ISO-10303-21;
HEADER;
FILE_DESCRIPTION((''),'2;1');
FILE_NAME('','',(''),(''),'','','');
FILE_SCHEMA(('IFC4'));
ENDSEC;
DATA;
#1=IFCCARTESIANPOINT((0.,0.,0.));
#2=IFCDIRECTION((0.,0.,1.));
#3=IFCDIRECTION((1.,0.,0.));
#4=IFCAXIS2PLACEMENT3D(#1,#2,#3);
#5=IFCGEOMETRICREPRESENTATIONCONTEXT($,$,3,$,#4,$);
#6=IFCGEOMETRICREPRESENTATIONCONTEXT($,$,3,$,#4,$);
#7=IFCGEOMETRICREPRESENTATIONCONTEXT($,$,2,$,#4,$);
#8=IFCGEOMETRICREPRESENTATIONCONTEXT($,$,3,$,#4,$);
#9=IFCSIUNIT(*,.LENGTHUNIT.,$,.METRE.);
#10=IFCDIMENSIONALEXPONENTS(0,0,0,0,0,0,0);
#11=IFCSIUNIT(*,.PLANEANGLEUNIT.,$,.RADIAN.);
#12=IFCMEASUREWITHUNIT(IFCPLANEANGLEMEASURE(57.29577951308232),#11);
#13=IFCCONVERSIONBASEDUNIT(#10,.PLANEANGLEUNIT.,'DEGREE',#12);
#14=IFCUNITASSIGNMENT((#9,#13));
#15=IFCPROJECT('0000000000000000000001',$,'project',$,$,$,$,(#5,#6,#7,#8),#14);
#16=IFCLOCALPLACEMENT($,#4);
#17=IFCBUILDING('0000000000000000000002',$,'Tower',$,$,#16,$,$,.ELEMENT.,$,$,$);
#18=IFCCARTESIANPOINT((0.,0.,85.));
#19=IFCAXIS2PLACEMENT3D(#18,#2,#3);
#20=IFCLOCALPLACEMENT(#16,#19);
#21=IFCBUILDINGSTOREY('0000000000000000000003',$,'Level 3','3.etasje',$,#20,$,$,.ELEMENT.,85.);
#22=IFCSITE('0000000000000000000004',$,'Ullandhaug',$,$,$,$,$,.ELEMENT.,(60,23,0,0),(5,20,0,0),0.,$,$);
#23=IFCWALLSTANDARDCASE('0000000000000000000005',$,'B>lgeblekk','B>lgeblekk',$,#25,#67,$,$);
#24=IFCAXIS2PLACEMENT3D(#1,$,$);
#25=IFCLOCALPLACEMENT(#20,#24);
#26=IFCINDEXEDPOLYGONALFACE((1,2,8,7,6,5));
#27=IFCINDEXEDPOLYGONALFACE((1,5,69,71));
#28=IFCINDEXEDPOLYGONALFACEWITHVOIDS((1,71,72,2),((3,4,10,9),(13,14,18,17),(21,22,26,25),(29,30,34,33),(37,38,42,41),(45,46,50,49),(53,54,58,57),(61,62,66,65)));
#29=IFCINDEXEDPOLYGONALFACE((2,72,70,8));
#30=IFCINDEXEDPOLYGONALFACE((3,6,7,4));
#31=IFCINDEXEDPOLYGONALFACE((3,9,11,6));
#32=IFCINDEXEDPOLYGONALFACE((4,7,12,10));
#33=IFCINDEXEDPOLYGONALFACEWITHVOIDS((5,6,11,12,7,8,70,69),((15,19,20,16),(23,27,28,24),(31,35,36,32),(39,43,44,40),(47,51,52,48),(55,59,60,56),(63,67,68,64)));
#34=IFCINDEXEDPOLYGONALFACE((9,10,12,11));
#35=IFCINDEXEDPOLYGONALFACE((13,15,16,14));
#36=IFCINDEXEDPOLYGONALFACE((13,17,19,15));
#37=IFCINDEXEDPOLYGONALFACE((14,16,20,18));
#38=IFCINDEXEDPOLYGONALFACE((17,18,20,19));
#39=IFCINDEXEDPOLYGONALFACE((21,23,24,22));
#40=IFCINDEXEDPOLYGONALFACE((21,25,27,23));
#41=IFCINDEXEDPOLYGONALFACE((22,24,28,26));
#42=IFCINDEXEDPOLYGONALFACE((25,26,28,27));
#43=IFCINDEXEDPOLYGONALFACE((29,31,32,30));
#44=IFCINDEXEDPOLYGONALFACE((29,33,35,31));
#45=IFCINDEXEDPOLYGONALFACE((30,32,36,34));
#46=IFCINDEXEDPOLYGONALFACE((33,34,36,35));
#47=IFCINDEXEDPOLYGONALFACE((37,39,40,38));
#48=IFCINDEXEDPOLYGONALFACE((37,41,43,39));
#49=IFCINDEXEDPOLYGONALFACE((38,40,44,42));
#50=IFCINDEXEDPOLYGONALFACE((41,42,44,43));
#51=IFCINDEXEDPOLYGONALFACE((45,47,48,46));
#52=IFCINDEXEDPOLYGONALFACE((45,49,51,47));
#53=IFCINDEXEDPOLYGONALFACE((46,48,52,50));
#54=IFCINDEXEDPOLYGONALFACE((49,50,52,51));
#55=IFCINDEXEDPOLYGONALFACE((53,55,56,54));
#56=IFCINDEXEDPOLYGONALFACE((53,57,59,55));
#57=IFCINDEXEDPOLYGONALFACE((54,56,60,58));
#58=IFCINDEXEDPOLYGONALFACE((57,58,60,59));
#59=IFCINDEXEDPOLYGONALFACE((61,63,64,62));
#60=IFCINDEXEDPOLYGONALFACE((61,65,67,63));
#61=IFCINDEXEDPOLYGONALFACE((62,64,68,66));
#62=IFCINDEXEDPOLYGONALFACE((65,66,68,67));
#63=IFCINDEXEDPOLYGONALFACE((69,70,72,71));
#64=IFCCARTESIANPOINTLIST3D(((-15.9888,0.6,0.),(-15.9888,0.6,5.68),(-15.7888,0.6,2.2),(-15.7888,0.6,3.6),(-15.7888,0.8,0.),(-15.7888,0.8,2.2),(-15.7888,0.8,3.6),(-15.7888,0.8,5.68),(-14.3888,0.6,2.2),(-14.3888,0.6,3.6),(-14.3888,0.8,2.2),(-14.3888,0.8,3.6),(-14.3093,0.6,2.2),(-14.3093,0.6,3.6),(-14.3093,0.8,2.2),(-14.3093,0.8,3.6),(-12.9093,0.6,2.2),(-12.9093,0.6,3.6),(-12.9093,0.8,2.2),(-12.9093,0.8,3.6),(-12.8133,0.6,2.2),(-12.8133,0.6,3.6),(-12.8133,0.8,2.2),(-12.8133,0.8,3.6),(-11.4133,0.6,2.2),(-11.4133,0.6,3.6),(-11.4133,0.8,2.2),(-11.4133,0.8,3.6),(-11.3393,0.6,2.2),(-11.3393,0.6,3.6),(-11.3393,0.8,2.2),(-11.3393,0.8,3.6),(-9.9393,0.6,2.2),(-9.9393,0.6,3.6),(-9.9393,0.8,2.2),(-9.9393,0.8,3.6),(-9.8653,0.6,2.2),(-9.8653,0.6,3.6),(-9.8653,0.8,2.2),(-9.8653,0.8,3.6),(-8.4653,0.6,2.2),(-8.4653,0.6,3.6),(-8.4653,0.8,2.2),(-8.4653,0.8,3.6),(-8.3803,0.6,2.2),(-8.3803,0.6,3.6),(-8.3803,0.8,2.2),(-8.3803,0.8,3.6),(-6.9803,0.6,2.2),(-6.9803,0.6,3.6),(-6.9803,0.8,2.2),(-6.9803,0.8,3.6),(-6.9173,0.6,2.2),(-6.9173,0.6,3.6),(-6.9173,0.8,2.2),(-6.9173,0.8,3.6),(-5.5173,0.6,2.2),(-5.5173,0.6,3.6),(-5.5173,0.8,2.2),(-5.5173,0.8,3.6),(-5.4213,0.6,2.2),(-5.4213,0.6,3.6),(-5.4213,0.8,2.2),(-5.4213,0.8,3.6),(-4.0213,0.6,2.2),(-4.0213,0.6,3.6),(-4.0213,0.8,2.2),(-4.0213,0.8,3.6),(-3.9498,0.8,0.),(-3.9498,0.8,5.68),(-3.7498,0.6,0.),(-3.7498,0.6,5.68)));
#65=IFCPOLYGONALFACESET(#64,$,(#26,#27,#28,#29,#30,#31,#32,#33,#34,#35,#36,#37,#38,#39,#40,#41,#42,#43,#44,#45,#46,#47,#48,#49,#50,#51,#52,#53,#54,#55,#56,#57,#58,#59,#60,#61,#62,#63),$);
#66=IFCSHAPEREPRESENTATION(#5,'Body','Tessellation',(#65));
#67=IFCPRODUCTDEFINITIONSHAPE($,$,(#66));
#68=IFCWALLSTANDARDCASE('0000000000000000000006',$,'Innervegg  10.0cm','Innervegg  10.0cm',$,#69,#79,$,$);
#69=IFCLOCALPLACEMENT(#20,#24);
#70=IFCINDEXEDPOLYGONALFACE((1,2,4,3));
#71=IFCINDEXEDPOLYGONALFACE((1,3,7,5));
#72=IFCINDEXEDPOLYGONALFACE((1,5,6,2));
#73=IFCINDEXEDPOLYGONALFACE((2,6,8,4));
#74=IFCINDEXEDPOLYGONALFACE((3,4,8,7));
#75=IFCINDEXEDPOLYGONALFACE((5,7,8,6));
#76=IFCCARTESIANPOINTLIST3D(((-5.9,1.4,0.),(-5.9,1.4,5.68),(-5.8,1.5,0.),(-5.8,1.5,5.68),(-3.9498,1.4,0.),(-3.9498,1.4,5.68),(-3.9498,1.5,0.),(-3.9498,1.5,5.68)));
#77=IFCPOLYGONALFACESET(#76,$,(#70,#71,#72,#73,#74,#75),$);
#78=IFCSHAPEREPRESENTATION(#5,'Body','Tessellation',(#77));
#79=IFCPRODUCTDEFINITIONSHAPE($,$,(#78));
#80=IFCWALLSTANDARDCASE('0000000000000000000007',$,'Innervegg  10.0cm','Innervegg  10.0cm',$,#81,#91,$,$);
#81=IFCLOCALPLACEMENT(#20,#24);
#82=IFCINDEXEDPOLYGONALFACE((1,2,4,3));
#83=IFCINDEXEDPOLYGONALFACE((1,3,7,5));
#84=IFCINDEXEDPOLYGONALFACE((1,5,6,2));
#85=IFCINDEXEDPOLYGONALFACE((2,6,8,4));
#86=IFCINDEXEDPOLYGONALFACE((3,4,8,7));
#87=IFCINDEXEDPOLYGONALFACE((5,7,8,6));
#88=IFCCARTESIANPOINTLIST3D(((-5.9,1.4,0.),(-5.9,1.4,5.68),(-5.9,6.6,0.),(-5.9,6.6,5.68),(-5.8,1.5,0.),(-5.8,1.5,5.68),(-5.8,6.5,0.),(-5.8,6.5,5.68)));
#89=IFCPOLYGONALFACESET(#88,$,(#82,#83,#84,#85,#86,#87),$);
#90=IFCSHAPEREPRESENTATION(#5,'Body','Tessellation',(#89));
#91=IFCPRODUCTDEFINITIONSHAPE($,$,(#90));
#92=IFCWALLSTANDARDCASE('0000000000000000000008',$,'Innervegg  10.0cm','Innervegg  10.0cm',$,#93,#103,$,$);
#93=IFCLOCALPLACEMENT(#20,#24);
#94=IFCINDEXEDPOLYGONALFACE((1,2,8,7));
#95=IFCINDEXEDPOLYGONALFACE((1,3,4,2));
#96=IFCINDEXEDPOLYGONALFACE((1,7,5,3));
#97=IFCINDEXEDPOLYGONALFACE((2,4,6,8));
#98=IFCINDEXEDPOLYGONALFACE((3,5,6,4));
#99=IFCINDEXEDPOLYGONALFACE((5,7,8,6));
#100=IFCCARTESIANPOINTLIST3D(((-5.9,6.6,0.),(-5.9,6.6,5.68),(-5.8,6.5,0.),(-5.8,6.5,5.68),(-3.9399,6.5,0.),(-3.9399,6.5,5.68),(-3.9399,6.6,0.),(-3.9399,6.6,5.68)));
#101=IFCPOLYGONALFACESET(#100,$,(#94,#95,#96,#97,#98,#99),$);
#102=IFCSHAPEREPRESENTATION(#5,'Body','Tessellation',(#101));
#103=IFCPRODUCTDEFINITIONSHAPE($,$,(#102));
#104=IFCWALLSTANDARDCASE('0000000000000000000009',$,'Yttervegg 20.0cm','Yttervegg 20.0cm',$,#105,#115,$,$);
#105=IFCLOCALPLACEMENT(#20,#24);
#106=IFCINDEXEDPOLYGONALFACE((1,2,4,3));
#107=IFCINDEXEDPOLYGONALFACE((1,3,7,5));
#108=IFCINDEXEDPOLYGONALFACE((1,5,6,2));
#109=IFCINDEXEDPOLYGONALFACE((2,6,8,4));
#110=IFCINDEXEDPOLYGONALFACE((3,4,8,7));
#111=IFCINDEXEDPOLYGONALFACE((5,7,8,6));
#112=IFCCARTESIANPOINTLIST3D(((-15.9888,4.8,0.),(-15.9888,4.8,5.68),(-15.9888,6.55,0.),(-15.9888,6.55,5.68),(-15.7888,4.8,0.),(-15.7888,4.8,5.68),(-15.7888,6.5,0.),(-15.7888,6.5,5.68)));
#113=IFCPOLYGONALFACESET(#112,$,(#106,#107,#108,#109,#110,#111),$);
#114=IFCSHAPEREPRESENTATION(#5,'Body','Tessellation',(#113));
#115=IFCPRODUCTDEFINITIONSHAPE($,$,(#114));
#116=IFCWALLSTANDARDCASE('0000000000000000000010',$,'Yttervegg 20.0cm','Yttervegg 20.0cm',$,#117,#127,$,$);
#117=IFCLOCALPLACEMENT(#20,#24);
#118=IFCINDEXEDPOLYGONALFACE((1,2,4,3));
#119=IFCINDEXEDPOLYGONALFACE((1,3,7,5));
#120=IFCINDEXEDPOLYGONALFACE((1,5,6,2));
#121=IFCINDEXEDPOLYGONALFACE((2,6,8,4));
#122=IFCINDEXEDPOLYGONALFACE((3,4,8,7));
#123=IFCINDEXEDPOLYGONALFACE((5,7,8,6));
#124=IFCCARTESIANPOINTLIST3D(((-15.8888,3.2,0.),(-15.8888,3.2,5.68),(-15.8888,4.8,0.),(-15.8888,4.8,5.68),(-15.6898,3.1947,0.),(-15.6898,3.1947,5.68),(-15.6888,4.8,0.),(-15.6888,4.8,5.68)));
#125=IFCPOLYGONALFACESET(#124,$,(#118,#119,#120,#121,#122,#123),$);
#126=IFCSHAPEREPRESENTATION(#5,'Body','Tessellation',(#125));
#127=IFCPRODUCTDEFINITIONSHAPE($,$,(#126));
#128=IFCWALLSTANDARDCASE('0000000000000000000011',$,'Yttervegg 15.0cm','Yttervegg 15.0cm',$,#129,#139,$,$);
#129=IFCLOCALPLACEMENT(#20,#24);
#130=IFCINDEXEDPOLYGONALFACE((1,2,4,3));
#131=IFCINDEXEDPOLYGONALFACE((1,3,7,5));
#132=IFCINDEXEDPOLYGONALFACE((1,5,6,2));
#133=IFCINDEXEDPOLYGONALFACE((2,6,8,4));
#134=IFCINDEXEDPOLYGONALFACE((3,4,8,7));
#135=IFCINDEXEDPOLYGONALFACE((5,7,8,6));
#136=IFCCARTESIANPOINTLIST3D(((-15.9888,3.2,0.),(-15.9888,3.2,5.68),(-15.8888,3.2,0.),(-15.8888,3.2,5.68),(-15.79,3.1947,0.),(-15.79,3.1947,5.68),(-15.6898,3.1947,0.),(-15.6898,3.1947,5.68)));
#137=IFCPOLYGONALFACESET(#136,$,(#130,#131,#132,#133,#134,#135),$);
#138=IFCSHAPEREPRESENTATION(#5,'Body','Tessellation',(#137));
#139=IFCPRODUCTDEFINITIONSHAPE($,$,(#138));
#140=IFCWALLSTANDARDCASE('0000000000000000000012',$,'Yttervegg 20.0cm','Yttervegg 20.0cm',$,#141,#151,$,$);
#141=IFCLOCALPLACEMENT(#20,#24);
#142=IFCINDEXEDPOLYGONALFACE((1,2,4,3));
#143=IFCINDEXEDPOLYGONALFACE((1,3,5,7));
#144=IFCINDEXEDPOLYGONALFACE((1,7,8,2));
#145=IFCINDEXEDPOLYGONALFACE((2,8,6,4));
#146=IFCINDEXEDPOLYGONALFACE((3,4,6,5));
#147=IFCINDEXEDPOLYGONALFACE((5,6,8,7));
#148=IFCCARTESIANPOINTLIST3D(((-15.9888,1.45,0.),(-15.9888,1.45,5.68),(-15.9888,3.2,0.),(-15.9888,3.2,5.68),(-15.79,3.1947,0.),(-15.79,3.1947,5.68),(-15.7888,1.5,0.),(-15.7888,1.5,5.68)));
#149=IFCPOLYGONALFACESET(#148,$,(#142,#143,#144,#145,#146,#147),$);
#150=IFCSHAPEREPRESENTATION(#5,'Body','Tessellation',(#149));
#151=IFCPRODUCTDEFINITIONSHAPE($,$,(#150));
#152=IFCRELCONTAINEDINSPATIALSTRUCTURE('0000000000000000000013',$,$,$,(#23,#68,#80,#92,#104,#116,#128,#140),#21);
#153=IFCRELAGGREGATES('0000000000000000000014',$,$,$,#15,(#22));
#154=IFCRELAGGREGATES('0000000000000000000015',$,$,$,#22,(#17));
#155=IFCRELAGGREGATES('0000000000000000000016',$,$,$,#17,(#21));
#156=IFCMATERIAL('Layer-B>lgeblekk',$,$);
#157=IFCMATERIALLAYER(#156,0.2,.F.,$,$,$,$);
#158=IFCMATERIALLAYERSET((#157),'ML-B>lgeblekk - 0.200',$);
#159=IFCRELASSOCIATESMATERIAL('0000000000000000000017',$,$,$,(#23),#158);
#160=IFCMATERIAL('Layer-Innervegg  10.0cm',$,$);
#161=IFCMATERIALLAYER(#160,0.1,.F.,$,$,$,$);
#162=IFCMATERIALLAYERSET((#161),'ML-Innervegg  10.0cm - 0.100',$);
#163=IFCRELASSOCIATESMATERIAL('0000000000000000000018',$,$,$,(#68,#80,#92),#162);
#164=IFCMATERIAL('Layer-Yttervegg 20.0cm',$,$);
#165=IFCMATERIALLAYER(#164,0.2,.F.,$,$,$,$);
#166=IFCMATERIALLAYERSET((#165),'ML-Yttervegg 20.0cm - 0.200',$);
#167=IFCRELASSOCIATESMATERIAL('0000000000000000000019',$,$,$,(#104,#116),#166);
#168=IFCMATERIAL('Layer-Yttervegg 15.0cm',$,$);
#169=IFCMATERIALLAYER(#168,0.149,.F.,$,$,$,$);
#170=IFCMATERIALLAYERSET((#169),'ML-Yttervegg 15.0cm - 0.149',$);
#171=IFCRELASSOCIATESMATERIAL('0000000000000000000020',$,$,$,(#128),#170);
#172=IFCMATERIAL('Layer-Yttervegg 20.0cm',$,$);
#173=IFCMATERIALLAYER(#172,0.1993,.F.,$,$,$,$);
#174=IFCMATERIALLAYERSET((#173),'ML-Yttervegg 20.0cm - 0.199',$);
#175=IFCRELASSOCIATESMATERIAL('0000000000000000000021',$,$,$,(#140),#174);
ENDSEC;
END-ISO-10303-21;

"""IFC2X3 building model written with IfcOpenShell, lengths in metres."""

from ifc_helpers import new_model, entity, si_unit, converted_unit, frame, origin_with_axes, place, context, project, spatial, polyline, outline, extrude, material, layer, layer_set, layer_usage, element, save


model = new_model("IFC2X3")

# Units and contexts
context_of_model_1 = context(None, 3, world=origin_with_axes())
context_of_model_2 = context(None, 3, world=origin_with_axes())
context_of_model_3 = context(None, 2, world=origin_with_axes())
context_of_model_4 = context(None, 3, world=origin_with_axes())
ifc_project = project(units=[si_unit("LENGTHUNIT", "METRE"), converted_unit("PLANEANGLEUNIT", "DEGREE", entity("IfcPlaneAngleMeasure", 57.29577951308232), si_unit("PLANEANGLEUNIT", "RADIAN"), dimensions=[0, 0, 0, 0, 0, 0, 0])], contexts=[context_of_model_1, context_of_model_2, context_of_model_3, context_of_model_4])

# Site, building, storey
site = spatial("IfcSite", under=ifc_project, Name="Ullandhaug", CompositionType="ELEMENT", RefLatitude=(60, 23, 0, 0), RefLongitude=(5, 20, 0, 0), RefElevation=0.0)
building_placement = place(None, origin_with_axes())
building = spatial("IfcBuilding", under=site, at=building_placement, Name="Tower", CompositionType="ELEMENT")
storey_placement = place(building_placement, frame((0.0, 0.0, 85.0), z_axis=(0.0, 0.0, 1.0), x_axis=(1.0, 0.0, 0.0)))
storey = spatial("IfcBuildingStorey", under=building, at=storey_placement, Name="Level 3", Description="3.etasje", CompositionType="ELEMENT", Elevation=85.0)

# Shared definitions
ifc_material_1 = material(Name="Layer-Innervegg  10.0cm")
ifc_layer_1 = layer(ifc_material_1, 0.1, ventilated=False)
ifc_layer_set_1 = layer_set([ifc_layer_1], Name="ML-Innervegg  10.0cm - 0.100")
ifc_layer_usage_1 = layer_usage(ifc_layer_set_1, "AXIS2", "POSITIVE", 0.0)

# Wall, openings
ifc_material_2 = material(Name="Layer-B>lgeblekk")
ifc_layer_2 = layer(ifc_material_2, 0.2, ventilated=False)
ifc_layer_set_2 = layer_set([ifc_layer_2], Name="ML-B>lgeblekk - 0.200")
ifc_layer_usage_2 = layer_usage(ifc_layer_set_2, "AXIS2", "POSITIVE", 0.0)
wall_1_placement = place(storey_placement, frame((-15.9888, 0.6, 0.0), z_axis=(0.0, 0.0, 1.0), x_axis=(1.0, 0.0, 0.0)))
wall_1 = element("IfcWallStandardCase", 1, at=wall_1_placement, inside=storey, material=ifc_layer_usage_2, Name="B>lgeblekk", Description="B>lgeblekk", context=context_of_model_1, shape_type="SweptSolid", body=[
    extrude(outline(polyline([(0.0, 0.0), (12.2391, 0.0), (12.0391, 0.2), (0.2, 0.2), (0.0, 0.0)])), origin_with_axes(), (0.0, 0.0, 1.0), 5.68),
])
opening_1_placement = place(wall_1_placement, frame((0.2, 0.2, 2.2), z_axis=(0.0, 0.0, 1.0), x_axis=(1.0, 0.0, 0.0)))
element("IfcOpeningElement", 2, at=opening_1_placement, cuts=wall_1, context=context_of_model_1, shape_type="SweptSolid", body=[
    extrude(outline(polyline([(0.0, 0.0), (1.4, 0.0), (1.4, 1.4), (0.0, 1.4), (0.0, 0.0)])), frame((0.0, 0.0, 0.0), z_axis=(0.0, 1.0, 0.0), x_axis=(0.0, 0.0, 1.0)), (0.0, 0.0, -1.0), 0.2),
])
opening_2_placement = place(wall_1_placement, frame((1.6796, 0.2, 2.2), z_axis=(0.0, 0.0, 1.0), x_axis=(1.0, 0.0, 0.0)))
element("IfcOpeningElement", 3, at=opening_2_placement, cuts=wall_1, context=context_of_model_1, shape_type="SweptSolid", body=[
    extrude(outline(polyline([(0.0, 0.0), (1.4, 0.0), (1.4, 1.4), (0.0, 1.4), (0.0, 0.0)])), frame((0.0, 0.0, 0.0), z_axis=(0.0, 1.0, 0.0), x_axis=(0.0, 0.0, 1.0)), (0.0, 0.0, -1.0), 0.2),
])
opening_3_placement = place(wall_1_placement, frame((3.1756, 0.2, 2.2), z_axis=(0.0, 0.0, 1.0), x_axis=(1.0, 0.0, 0.0)))
element("IfcOpeningElement", 4, at=opening_3_placement, cuts=wall_1, context=context_of_model_1, shape_type="SweptSolid", body=[
    extrude(outline(polyline([(0.0, 0.0), (1.4, 0.0), (1.4, 1.4), (0.0, 1.4), (0.0, 0.0)])), frame((0.0, 0.0, 0.0), z_axis=(0.0, 1.0, 0.0), x_axis=(0.0, 0.0, 1.0)), (0.0, 0.0, -1.0), 0.2),
])
opening_4_placement = place(wall_1_placement, frame((4.6496, 0.2, 2.2), z_axis=(0.0, 0.0, 1.0), x_axis=(1.0, 0.0, 0.0)))
element("IfcOpeningElement", 5, at=opening_4_placement, cuts=wall_1, context=context_of_model_1, shape_type="SweptSolid", body=[
    extrude(outline(polyline([(0.0, 0.0), (1.4, 0.0), (1.4, 1.4), (0.0, 1.4), (0.0, 0.0)])), frame((0.0, 0.0, 0.0), z_axis=(0.0, 1.0, 0.0), x_axis=(0.0, 0.0, 1.0)), (0.0, 0.0, -1.0), 0.2),
])
opening_5_placement = place(wall_1_placement, frame((6.1236, 0.2, 2.2), z_axis=(0.0, 0.0, 1.0), x_axis=(1.0, 0.0, 0.0)))
element("IfcOpeningElement", 6, at=opening_5_placement, cuts=wall_1, context=context_of_model_1, shape_type="SweptSolid", body=[
    extrude(outline(polyline([(0.0, 0.0), (1.4, 0.0), (1.4, 1.4), (0.0, 1.4), (0.0, 0.0)])), frame((0.0, 0.0, 0.0), z_axis=(0.0, 1.0, 0.0), x_axis=(0.0, 0.0, 1.0)), (0.0, 0.0, -1.0), 0.2),
])
opening_6_placement = place(wall_1_placement, frame((7.6086, 0.2, 2.2), z_axis=(0.0, 0.0, 1.0), x_axis=(1.0, 0.0, 0.0)))
element("IfcOpeningElement", 7, at=opening_6_placement, cuts=wall_1, context=context_of_model_1, shape_type="SweptSolid", body=[
    extrude(outline(polyline([(0.0, 0.0), (1.4, 0.0), (1.4, 1.4), (0.0, 1.4), (0.0, 0.0)])), frame((0.0, 0.0, 0.0), z_axis=(0.0, 1.0, 0.0), x_axis=(0.0, 0.0, 1.0)), (0.0, 0.0, -1.0), 0.2),
])
opening_7_placement = place(wall_1_placement, frame((9.0716, 0.2, 2.2), z_axis=(0.0, 0.0, 1.0), x_axis=(1.0, 0.0, 0.0)))
element("IfcOpeningElement", 8, at=opening_7_placement, cuts=wall_1, context=context_of_model_1, shape_type="SweptSolid", body=[
    extrude(outline(polyline([(0.0, 0.0), (1.4, 0.0), (1.4, 1.4), (0.0, 1.4), (0.0, 0.0)])), frame((0.0, 0.0, 0.0), z_axis=(0.0, 1.0, 0.0), x_axis=(0.0, 0.0, 1.0)), (0.0, 0.0, -1.0), 0.2),
])
opening_8_placement = place(wall_1_placement, frame((10.5676, 0.2, 2.2), z_axis=(0.0, 0.0, 1.0), x_axis=(1.0, 0.0, 0.0)))
element("IfcOpeningElement", 9, at=opening_8_placement, cuts=wall_1, context=context_of_model_1, shape_type="SweptSolid", body=[
    extrude(outline(polyline([(0.0, 0.0), (1.4, 0.0), (1.4, 1.4), (0.0, 1.4), (0.0, 0.0)])), frame((0.0, 0.0, 0.0), z_axis=(0.0, 1.0, 0.0), x_axis=(0.0, 0.0, 1.0)), (0.0, 0.0, -1.0), 0.2),
])

# Walls
wall_2_placement = place(storey_placement, frame((-3.9498, 1.5, 0.0), z_axis=(0.0, 0.0, 1.0), x_axis=(-1.0, 0.0, 0.0)))
element("IfcWallStandardCase", 10, at=wall_2_placement, inside=storey, material=ifc_layer_usage_1, Name="Innervegg  10.0cm", Description="Innervegg  10.0cm", context=context_of_model_1, shape_type="SweptSolid", body=[
    extrude(outline(polyline([(0.0, 0.0), (1.8502, 0.0), (1.9502, 0.1), (0.0, 0.1), (0.0, 0.0)])), frame((0.0, 0.0, 0.0), z_axis=(0.0, 0.0, 1.0), x_axis=(1.0, 0.0, 0.0)), (0.0, 0.0, 1.0), 5.68),
])
wall_3_placement = place(storey_placement, frame((-5.8, 1.5, 0.0), z_axis=(0.0, 0.0, 1.0), x_axis=(0.0, 1.0, 0.0)))
element("IfcWallStandardCase", 11, at=wall_3_placement, inside=storey, material=ifc_layer_usage_1, Name="Innervegg  10.0cm", Description="Innervegg  10.0cm", context=context_of_model_1, shape_type="SweptSolid", body=[
    extrude(outline(polyline([(0.0, 0.0), (5.0, 0.0), (5.1, 0.1), (-0.1, 0.1), (0.0, 0.0)])), frame((0.0, 0.0, 0.0), z_axis=(0.0, 0.0, 1.0), x_axis=(1.0, 0.0, 0.0)), (0.0, 0.0, 1.0), 5.68),
])
wall_4_placement = place(storey_placement, frame((-5.8, 6.5, 0.0), z_axis=(0.0, 0.0, 1.0), x_axis=(1.0, 0.0, 0.0)))
element("IfcWallStandardCase", 12, at=wall_4_placement, inside=storey, material=ifc_layer_usage_1, Name="Innervegg  10.0cm", Description="Innervegg  10.0cm", context=context_of_model_1, shape_type="SweptSolid", body=[
    extrude(outline(polyline([(0.0, 0.0), (1.8601, 0.0), (1.8601, 0.1), (-0.1, 0.1), (0.0, 0.0)])), origin_with_axes(), (0.0, 0.0, 1.0), 5.68),
])
ifc_material_3 = material(Name="Layer-Yttervegg 20.0cm")
ifc_layer_3 = layer(ifc_material_3, 0.2, ventilated=False)
ifc_layer_set_3 = layer_set([ifc_layer_3], Name="ML-Yttervegg 20.0cm - 0.200")
ifc_layer_usage_3 = layer_usage(ifc_layer_set_3, "AXIS2", "POSITIVE", 0.0)
wall_5_placement = place(storey_placement, frame((-15.9888, 6.55, 0.0), z_axis=(0.0, 0.0, 1.0), x_axis=(0.0, -1.0, 0.0)))
element("IfcWallStandardCase", 13, at=wall_5_placement, inside=storey, material=ifc_layer_usage_3, Name="Yttervegg 20.0cm", Description="Yttervegg 20.0cm", context=context_of_model_1, shape_type="SweptSolid", body=[
    extrude(outline(polyline([(0.0, 0.0), (1.75, 0.0), (1.75, 0.2), (0.05, 0.2), (0.0, 0.0)])), frame((0.0, 0.0, 0.0), z_axis=(0.0, 0.0, 1.0), x_axis=(1.0, 0.0, 0.0)), (0.0, 0.0, 1.0), 5.68),
])
wall_6_placement = place(storey_placement, frame((-15.8888, 4.8, 0.0), z_axis=(0.0, 0.0, 1.0), x_axis=(0.000001, -1.0, 0.0)))
element("IfcWallStandardCase", 14, at=wall_6_placement, inside=storey, material=ifc_layer_usage_3, Name="Yttervegg 20.0cm", Description="Yttervegg 20.0cm", context=context_of_model_1, shape_type="SweptSolid", body=[
    extrude(outline(polyline([(0.0, 0.0), (1.6, 0.0), (1.6053, 0.199), (0.0, 0.2), (0.0, 0.0)])), frame((0.0, 0.0, 0.0), z_axis=(0.0, 0.0, 1.0), x_axis=(1.0, 0.0, 0.0)), (0.0, 0.0, 1.0), 5.68),
])
ifc_material_4 = material(Name="Layer-Yttervegg 15.0cm")
ifc_layer_4 = layer(ifc_material_4, 0.149, ventilated=False)
ifc_layer_set_4 = layer_set([ifc_layer_4], Name="ML-Yttervegg 15.0cm - 0.149")
ifc_layer_usage_4 = layer_usage(ifc_layer_set_4, "AXIS2", "POSITIVE", 0.0)
wall_7_placement = place(storey_placement, frame((-15.8888, 3.2, 0.0), z_axis=(0.0, 0.0, 1.0), x_axis=(-1.0, 0.0, 0.0)))
element("IfcWallStandardCase", 15, at=wall_7_placement, inside=storey, material=ifc_layer_usage_4, Name="Yttervegg 15.0cm", Description="Yttervegg 15.0cm", context=context_of_model_1, shape_type="SweptSolid", body=[
    extrude(outline(polyline([(0.0, 0.0), (0.1, 0.0), (-0.0989, 0.0053), (-0.199, 0.0053), (0.0, 0.0)])), frame((0.0, 0.0, 0.0), z_axis=(0.0, 0.0, 1.0), x_axis=(1.0, 0.0, 0.0)), (0.0, 0.0, 1.0), 5.68),
])
ifc_material_5 = material(Name="Layer-Yttervegg 20.0cm")
ifc_layer_5 = layer(ifc_material_5, 0.1993, ventilated=False)
ifc_layer_set_5 = layer_set([ifc_layer_5], Name="ML-Yttervegg 20.0cm - 0.199")
ifc_layer_usage_5 = layer_usage(ifc_layer_set_5, "AXIS2", "POSITIVE", 0.0)
wall_8_placement = place(storey_placement, frame((-15.9888, 3.2, 0.0), z_axis=(0.0, 0.0, 1.0), x_axis=(0.0, -1.0, 0.0)))
element("IfcWallStandardCase", 16, at=wall_8_placement, inside=storey, material=ifc_layer_usage_5, Name="Yttervegg 20.0cm", Description="Yttervegg 20.0cm", context=context_of_model_1, shape_type="SweptSolid", body=[
    extrude(outline(polyline([(0.0, 0.0), (1.75, 0.0), (1.7, 0.2), (0.0053, 0.1989), (0.0, 0.0)])), frame((0.0, 0.0, 0.0), z_axis=(0.0, 0.0, 1.0), x_axis=(1.0, 0.0, 0.0)), (0.0, 0.0, 1.0), 5.68),
])

save(model, "model.ifc")
